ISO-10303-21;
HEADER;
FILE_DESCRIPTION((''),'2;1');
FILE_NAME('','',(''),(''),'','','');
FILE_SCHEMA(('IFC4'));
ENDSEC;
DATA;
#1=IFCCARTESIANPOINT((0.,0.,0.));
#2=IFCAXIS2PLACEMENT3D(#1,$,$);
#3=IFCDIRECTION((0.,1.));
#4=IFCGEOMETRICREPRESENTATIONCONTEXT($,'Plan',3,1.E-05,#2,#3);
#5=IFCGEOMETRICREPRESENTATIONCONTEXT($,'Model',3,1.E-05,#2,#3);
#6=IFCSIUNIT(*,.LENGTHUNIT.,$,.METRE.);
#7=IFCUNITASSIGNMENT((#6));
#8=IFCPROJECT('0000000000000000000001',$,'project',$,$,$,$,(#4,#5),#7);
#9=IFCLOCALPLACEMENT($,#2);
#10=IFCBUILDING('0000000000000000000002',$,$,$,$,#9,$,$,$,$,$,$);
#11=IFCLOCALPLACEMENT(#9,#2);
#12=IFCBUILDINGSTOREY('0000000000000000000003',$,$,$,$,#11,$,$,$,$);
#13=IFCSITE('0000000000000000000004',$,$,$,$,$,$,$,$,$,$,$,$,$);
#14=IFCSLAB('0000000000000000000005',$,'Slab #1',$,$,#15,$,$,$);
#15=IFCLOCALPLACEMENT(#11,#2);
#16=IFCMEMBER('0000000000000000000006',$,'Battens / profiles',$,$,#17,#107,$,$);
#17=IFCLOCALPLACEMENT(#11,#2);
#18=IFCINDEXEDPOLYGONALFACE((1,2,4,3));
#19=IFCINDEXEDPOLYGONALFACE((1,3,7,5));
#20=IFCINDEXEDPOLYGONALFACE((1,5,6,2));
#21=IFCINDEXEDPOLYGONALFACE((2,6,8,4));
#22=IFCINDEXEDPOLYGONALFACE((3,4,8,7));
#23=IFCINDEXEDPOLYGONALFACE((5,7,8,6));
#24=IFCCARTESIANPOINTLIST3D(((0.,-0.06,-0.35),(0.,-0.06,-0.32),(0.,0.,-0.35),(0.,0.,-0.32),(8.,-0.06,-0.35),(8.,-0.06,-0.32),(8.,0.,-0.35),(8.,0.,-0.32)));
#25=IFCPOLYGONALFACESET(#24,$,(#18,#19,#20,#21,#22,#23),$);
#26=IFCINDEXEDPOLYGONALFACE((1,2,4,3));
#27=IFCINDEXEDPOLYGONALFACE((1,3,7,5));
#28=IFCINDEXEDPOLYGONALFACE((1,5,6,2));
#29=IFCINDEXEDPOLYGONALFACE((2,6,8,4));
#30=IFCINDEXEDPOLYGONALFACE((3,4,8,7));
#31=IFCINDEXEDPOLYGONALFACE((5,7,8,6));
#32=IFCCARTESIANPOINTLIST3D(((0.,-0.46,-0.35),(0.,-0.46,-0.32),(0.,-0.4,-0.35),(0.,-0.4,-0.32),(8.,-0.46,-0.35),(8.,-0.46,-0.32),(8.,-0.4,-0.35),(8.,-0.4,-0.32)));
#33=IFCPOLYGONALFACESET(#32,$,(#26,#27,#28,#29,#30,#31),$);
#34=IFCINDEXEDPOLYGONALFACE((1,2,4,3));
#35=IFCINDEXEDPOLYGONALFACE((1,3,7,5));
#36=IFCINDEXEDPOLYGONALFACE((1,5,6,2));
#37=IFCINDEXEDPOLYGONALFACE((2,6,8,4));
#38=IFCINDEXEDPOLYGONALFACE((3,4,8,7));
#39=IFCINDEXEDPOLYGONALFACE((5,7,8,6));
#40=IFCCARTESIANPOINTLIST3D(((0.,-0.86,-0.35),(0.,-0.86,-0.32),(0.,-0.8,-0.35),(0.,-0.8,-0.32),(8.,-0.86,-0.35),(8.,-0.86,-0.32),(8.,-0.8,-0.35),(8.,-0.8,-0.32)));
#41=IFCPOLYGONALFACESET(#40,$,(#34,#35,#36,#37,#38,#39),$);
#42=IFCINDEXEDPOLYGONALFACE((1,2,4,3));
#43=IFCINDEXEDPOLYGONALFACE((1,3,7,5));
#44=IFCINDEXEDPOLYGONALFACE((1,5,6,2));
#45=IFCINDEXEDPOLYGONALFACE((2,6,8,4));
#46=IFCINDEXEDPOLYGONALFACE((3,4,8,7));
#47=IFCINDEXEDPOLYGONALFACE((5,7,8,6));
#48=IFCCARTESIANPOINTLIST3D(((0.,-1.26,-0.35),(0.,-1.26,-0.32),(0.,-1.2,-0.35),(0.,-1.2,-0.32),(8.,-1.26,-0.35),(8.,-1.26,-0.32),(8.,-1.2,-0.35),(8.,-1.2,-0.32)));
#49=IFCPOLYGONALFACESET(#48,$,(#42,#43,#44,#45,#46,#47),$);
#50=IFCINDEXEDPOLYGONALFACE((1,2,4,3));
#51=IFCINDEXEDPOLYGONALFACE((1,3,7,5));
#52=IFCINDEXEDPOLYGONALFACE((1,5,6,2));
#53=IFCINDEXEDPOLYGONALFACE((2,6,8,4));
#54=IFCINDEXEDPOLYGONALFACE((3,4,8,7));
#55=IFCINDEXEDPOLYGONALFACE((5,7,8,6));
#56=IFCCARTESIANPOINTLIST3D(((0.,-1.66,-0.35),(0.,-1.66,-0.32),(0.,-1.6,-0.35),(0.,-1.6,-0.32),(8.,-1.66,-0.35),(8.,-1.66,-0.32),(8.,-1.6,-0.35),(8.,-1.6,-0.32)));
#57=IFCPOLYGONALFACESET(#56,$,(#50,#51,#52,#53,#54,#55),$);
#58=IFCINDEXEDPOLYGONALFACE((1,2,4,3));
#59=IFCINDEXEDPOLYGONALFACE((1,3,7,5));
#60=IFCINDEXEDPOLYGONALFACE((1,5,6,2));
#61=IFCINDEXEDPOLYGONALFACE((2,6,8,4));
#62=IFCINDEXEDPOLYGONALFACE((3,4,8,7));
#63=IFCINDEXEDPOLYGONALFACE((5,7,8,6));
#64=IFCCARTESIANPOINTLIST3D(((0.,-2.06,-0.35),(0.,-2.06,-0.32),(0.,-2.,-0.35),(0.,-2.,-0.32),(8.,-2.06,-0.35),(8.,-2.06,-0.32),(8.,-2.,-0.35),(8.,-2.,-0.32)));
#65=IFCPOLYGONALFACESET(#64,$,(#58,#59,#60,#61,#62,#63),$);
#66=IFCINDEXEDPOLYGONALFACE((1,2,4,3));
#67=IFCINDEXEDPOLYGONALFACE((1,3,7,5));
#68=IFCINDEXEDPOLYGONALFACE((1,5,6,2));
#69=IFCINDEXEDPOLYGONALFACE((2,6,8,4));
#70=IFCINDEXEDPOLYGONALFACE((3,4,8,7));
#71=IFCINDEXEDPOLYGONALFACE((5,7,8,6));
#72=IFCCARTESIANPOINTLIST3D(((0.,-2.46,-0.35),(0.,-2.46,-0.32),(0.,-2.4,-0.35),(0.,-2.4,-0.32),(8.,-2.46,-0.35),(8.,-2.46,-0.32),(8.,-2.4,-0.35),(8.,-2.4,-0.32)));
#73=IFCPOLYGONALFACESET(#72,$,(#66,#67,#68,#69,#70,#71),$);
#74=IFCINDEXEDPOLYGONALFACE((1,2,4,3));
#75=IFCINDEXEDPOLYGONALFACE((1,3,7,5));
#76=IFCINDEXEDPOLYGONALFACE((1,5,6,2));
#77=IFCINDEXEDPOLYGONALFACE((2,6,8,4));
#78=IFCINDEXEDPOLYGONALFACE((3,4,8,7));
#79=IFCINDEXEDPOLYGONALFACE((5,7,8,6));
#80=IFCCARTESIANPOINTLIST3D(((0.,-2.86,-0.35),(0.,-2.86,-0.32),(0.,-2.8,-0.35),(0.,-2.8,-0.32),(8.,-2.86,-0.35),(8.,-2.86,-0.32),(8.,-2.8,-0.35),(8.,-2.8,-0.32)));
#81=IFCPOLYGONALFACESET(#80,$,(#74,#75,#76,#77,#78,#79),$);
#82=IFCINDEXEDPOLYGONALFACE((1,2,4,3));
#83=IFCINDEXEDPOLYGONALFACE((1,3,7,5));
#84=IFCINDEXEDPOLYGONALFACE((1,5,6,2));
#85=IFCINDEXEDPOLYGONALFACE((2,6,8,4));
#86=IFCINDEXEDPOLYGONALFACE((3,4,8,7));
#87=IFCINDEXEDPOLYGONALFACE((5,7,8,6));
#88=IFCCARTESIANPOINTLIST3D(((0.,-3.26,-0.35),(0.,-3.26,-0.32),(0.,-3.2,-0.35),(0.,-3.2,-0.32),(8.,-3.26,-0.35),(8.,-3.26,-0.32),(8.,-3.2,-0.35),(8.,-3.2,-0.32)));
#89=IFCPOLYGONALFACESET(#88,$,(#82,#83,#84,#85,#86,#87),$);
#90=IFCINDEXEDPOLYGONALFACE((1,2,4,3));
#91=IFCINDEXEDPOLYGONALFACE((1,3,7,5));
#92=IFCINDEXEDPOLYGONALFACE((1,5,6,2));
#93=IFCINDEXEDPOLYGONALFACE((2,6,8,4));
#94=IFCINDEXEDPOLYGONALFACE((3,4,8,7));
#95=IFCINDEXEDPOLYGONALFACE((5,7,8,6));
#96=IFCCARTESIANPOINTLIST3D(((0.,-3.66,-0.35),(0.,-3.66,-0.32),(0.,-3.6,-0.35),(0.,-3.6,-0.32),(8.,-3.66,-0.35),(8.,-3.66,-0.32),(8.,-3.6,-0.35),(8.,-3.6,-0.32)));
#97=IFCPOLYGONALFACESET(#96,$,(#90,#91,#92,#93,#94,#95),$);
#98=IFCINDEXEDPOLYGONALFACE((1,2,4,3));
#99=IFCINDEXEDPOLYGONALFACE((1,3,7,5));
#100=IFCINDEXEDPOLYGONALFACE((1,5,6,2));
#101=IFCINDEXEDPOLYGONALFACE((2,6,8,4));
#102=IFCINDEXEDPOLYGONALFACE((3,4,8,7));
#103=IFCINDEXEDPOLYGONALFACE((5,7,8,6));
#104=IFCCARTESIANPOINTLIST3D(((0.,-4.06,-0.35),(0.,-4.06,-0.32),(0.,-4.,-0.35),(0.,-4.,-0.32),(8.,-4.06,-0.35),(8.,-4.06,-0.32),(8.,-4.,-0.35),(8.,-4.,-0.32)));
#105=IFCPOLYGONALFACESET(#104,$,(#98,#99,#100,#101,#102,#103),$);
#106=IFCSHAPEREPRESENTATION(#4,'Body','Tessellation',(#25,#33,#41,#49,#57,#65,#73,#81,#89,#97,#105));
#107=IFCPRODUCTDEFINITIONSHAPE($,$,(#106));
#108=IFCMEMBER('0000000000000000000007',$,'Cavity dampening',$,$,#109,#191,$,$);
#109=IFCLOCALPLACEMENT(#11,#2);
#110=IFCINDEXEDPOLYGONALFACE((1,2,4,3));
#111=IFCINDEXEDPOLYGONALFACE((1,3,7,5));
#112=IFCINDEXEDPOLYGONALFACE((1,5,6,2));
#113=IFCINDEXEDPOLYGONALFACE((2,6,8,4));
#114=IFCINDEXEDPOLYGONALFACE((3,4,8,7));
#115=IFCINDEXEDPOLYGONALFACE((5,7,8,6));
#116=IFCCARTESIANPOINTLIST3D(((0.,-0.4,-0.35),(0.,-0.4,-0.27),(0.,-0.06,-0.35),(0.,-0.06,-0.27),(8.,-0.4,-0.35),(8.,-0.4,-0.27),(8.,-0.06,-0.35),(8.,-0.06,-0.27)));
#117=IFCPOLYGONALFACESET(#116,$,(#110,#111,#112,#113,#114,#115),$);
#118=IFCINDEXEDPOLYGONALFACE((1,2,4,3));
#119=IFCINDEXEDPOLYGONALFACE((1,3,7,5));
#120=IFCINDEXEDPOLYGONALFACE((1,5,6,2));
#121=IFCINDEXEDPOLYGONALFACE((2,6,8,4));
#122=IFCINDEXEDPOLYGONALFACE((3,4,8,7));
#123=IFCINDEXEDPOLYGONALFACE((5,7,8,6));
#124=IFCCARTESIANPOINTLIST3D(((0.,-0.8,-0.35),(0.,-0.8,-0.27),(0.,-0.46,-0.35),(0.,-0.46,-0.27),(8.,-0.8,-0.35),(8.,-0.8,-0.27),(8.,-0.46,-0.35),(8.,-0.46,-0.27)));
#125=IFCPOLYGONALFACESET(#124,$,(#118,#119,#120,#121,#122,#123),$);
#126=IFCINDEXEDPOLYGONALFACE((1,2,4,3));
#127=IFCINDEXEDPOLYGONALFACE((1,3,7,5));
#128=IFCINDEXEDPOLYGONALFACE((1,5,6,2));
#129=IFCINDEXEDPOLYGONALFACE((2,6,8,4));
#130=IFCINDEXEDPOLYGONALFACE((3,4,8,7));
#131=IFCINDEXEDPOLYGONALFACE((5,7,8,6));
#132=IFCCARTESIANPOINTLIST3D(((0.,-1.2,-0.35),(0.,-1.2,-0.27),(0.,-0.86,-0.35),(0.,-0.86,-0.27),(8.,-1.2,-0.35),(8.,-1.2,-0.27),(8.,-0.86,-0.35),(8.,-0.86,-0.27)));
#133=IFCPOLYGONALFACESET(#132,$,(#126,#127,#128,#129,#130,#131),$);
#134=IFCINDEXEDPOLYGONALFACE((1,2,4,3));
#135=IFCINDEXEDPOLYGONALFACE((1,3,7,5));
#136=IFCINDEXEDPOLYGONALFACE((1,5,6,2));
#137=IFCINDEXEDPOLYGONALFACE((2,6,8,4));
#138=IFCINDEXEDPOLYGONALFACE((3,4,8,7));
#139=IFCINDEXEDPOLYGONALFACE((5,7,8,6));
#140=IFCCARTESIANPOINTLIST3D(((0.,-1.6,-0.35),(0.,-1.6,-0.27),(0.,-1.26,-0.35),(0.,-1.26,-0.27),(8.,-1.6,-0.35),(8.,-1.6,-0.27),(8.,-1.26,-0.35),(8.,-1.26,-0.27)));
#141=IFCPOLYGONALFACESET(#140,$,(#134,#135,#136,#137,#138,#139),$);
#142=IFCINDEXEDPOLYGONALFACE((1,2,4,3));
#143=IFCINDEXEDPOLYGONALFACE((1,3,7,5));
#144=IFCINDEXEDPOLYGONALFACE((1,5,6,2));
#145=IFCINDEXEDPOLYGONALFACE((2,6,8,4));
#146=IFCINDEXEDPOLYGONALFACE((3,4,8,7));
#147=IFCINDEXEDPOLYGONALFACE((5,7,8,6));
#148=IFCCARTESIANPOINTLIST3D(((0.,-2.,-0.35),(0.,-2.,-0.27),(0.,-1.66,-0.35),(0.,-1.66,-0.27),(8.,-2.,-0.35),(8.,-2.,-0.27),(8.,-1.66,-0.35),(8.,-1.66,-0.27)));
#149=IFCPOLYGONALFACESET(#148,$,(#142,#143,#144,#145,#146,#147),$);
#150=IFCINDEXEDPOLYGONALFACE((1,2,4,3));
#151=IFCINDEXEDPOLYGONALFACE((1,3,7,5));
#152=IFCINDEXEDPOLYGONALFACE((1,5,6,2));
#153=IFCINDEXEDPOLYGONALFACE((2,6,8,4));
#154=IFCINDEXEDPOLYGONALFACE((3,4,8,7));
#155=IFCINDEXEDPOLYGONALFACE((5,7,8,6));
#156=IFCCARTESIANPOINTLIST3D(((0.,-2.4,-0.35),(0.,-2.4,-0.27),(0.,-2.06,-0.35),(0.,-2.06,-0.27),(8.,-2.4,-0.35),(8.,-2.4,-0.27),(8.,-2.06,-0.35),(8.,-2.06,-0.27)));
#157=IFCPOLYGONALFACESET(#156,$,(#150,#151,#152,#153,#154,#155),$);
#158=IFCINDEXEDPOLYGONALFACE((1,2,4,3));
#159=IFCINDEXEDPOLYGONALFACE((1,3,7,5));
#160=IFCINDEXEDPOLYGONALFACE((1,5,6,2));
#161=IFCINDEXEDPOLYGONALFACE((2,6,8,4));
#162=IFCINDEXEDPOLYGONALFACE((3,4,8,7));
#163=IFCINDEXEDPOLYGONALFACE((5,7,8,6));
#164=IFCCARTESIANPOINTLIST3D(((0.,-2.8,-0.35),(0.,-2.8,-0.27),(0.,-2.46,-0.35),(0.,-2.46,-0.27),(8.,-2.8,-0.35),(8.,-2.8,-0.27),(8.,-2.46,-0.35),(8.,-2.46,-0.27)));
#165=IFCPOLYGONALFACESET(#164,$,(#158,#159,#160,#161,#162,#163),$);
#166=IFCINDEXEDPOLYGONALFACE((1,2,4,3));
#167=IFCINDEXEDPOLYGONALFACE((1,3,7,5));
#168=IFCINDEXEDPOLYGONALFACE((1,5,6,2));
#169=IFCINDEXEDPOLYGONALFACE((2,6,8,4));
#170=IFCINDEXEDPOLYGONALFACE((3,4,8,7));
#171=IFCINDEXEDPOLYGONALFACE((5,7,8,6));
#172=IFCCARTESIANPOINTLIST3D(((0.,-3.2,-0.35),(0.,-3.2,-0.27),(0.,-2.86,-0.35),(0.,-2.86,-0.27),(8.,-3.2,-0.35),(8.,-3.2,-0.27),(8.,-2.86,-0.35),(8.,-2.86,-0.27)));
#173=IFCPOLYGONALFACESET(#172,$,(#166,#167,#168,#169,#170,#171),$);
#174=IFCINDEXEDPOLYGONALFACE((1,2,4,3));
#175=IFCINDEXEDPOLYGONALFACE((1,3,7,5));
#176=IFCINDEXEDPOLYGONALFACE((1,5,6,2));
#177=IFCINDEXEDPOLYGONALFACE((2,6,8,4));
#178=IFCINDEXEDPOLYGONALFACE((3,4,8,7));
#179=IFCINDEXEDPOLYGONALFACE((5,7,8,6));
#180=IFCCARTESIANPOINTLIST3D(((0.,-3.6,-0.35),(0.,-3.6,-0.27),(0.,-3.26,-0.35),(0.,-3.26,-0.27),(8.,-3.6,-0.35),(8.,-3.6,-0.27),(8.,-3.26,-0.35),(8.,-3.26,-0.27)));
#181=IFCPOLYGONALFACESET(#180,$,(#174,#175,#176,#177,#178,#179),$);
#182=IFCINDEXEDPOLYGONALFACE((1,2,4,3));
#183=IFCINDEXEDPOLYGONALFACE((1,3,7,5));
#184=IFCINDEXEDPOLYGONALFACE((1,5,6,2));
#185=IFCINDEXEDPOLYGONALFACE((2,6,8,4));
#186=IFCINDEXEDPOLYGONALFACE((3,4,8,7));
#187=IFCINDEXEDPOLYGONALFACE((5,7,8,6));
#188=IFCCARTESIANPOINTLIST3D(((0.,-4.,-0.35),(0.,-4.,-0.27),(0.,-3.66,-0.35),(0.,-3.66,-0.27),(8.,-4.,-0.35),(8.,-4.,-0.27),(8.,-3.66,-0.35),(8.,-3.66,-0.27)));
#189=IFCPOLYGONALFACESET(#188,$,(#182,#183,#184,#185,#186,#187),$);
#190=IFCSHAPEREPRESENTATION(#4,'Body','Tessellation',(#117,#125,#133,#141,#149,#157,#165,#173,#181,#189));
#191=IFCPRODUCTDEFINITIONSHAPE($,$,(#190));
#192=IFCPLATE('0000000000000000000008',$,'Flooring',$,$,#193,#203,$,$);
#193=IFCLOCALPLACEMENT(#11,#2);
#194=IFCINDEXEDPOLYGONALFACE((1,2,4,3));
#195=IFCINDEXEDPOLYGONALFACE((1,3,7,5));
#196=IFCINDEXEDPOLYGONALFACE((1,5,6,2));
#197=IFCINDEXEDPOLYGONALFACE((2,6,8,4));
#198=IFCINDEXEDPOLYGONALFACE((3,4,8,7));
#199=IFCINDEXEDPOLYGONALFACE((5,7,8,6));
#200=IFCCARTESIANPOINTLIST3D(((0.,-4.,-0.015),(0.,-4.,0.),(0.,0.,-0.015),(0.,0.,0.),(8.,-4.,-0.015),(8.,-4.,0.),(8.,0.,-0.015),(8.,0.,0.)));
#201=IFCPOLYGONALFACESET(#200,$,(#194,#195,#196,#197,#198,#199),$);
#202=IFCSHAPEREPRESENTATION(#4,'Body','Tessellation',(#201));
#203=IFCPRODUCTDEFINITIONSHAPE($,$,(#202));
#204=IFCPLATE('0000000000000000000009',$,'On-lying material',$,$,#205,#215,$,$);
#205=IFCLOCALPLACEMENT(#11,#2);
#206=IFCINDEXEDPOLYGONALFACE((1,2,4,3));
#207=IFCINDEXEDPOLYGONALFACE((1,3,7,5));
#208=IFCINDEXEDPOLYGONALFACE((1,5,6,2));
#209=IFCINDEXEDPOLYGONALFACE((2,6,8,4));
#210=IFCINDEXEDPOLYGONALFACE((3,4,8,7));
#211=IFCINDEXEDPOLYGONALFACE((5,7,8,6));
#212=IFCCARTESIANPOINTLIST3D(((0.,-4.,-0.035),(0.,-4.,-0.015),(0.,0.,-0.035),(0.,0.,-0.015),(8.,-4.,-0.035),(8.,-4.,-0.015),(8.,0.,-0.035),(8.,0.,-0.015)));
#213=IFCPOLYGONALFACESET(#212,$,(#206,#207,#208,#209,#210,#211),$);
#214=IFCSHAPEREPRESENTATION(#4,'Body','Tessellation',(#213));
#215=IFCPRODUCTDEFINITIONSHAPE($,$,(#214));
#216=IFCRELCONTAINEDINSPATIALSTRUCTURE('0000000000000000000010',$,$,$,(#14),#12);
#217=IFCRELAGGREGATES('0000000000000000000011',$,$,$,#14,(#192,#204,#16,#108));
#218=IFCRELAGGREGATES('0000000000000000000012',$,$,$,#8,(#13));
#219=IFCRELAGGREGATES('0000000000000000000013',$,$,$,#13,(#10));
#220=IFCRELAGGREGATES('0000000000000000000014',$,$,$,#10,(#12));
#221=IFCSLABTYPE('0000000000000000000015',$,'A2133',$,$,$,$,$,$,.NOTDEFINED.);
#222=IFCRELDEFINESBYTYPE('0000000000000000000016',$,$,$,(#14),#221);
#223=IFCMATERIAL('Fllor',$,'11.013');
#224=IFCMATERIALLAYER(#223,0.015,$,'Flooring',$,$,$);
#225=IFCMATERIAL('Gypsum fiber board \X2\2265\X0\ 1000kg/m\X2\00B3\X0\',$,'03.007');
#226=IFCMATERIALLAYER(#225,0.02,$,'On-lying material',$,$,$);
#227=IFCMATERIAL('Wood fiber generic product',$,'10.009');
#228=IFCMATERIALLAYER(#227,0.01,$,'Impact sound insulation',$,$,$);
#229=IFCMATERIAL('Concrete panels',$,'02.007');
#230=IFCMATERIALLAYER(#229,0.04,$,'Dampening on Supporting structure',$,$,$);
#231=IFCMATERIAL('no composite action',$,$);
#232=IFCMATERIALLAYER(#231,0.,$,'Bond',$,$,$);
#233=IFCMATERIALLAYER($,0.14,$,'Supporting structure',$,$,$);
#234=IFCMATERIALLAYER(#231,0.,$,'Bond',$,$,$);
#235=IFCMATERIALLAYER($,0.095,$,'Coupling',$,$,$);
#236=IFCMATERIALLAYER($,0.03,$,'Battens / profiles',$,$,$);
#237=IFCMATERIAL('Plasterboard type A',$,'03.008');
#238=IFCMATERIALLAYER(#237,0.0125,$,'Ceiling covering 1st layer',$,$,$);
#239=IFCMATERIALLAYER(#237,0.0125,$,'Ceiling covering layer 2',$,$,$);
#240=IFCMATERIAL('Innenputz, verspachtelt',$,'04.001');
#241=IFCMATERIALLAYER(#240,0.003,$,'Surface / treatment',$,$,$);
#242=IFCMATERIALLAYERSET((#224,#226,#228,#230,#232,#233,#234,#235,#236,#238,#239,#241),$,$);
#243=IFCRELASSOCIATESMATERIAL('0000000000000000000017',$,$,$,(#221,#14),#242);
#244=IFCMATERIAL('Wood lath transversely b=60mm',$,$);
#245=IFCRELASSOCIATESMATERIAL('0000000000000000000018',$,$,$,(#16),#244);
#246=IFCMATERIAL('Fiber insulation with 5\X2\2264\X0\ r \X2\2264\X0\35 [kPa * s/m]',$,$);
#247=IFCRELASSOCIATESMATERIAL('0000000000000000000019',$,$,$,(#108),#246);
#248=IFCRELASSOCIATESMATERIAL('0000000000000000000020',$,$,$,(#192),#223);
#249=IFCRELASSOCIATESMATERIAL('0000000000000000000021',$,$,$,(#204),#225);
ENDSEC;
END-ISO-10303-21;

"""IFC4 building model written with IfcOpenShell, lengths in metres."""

from ifc_helpers import new_model, si_unit, direction, frame, frame_2d, origin, origin_with_axes, place, context, project, spatial, rectangle, extrude, material, layer, layer_set, type_object, element, aggregate, save


model = new_model("IFC4")

# Units and contexts
plan_context = context("Plan", 3, precision=1e-05, world=origin(), true_north=direction((0.0, 1.0)))
model_context = context("Model", 3, precision=1e-05, world=origin(), true_north=direction((0.0, 1.0)))
ifc_project = project(units=[si_unit("LENGTHUNIT", "METRE")], contexts=[plan_context, model_context])

# Site, building, storey
site = spatial("IfcSite", under=ifc_project)
building_placement = place(None, origin())
building = spatial("IfcBuilding", under=site, at=building_placement)
storey_placement = place(building_placement, origin())
storey = spatial("IfcBuildingStorey", under=building, at=storey_placement)

# Slab, members, plates
ifc_material_1 = material(Name="Fllor", Category="11.013")
ifc_layer_1 = layer(ifc_material_1, 0.015, Name="Flooring")
ifc_material_2 = material(Name="Gypsum fiber board ≥ 1000kg/m³", Category="03.007")
ifc_layer_2 = layer(ifc_material_2, 0.02, Name="On-lying material")
ifc_material_3 = material(Name="Wood fiber generic product", Category="10.009")
ifc_layer_3 = layer(ifc_material_3, 0.01, Name="Impact sound insulation")
ifc_material_4 = material(Name="Concrete panels", Category="02.007")
ifc_layer_4 = layer(ifc_material_4, 0.04, Name="Dampening on Supporting structure")
ifc_material_5 = material(Name="no composite action")
ifc_layer_5 = layer(ifc_material_5, 0.0, Name="Bond")
ifc_layer_6 = layer(None, 0.14, Name="Supporting structure")
ifc_layer_7 = layer(ifc_material_5, 0.0, Name="Bond")
ifc_layer_8 = layer(None, 0.095, Name="Coupling")
ifc_layer_9 = layer(None, 0.03, Name="Battens / profiles")
ifc_material_6 = material(Name="Plasterboard type A", Category="03.008")
ifc_layer_10 = layer(ifc_material_6, 0.0125, Name="Ceiling covering 1st layer")
ifc_layer_11 = layer(ifc_material_6, 0.0125, Name="Ceiling covering layer 2")
ifc_material_7 = material(Name="Innenputz, verspachtelt", Category="04.001")
ifc_layer_12 = layer(ifc_material_7, 0.003, Name="Surface / treatment")
ifc_layer_set = layer_set([ifc_layer_1, ifc_layer_2, ifc_layer_3, ifc_layer_4, ifc_layer_5, ifc_layer_6, ifc_layer_7, ifc_layer_8, ifc_layer_9, ifc_layer_10, ifc_layer_11, ifc_layer_12])
slab_type = type_object("IfcSlabType", Name="A2133", PredefinedType="NOTDEFINED", material=ifc_layer_set)
slab_placement = place(None, frame((0.0, 0.0, 0.0), z_axis=(0.0, 0.0, -1.0), x_axis=(1.0, 0.0, 0.0)))
slab = element("IfcSlab", 1, at=slab_placement, inside=storey, type_object=slab_type, material=ifc_layer_set, Name="Slab #1")
ifc_material_8 = material(Name="Wood lath transversely b=60mm")
member_1_placement = place(slab_placement, origin())
member_1 = element("IfcMember", 2, at=member_1_placement, material=ifc_material_8, Name="Battens / profiles", context=plan_context, shape_type="SweptSolid", body=[
    extrude(rectangle(XDim=0.06, YDim=0.03, at=frame_2d((0.03, 0.015), x_axis=(1.0, 0.0))), frame((0.0, 0.0, 0.32), z_axis=(1.0, 0.0, 0.0), x_axis=(0.0, 1.0, 0.0)), (0.0, 0.0, 1.0), 8.0),
    extrude(rectangle(XDim=0.06, YDim=0.03, at=frame_2d((0.03, 0.015), x_axis=(1.0, 0.0))), frame((0.0, 0.4, 0.32), z_axis=(1.0, 0.0, 0.0), x_axis=(0.0, 1.0, 0.0)), (0.0, 0.0, 1.0), 8.0),
    extrude(rectangle(XDim=0.06, YDim=0.03, at=frame_2d((0.03, 0.015), x_axis=(1.0, 0.0))), frame((0.0, 0.8, 0.32), z_axis=(1.0, 0.0, 0.0), x_axis=(0.0, 1.0, 0.0)), (0.0, 0.0, 1.0), 8.0),
    extrude(rectangle(XDim=0.06, YDim=0.03, at=frame_2d((0.03, 0.015), x_axis=(1.0, 0.0))), frame((0.0, 1.2, 0.32), z_axis=(1.0, 0.0, 0.0), x_axis=(0.0, 1.0, 0.0)), (0.0, 0.0, 1.0), 8.0),
    extrude(rectangle(XDim=0.06, YDim=0.03, at=frame_2d((0.03, 0.015), x_axis=(1.0, 0.0))), frame((0.0, 1.6, 0.32), z_axis=(1.0, 0.0, 0.0), x_axis=(0.0, 1.0, 0.0)), (0.0, 0.0, 1.0), 8.0),
    extrude(rectangle(XDim=0.06, YDim=0.03, at=frame_2d((0.03, 0.015), x_axis=(1.0, 0.0))), frame((0.0, 2.0, 0.32), z_axis=(1.0, 0.0, 0.0), x_axis=(0.0, 1.0, 0.0)), (0.0, 0.0, 1.0), 8.0),
    extrude(rectangle(XDim=0.06, YDim=0.03, at=frame_2d((0.03, 0.015), x_axis=(1.0, 0.0))), frame((0.0, 2.4, 0.32), z_axis=(1.0, 0.0, 0.0), x_axis=(0.0, 1.0, 0.0)), (0.0, 0.0, 1.0), 8.0),
    extrude(rectangle(XDim=0.06, YDim=0.03, at=frame_2d((0.03, 0.015), x_axis=(1.0, 0.0))), frame((0.0, 2.8, 0.32), z_axis=(1.0, 0.0, 0.0), x_axis=(0.0, 1.0, 0.0)), (0.0, 0.0, 1.0), 8.0),
    extrude(rectangle(XDim=0.06, YDim=0.03, at=frame_2d((0.03, 0.015), x_axis=(1.0, 0.0))), frame((0.0, 3.2, 0.32), z_axis=(1.0, 0.0, 0.0), x_axis=(0.0, 1.0, 0.0)), (0.0, 0.0, 1.0), 8.0),
    extrude(rectangle(XDim=0.06, YDim=0.03, at=frame_2d((0.03, 0.015), x_axis=(1.0, 0.0))), frame((0.0, 3.6, 0.32), z_axis=(1.0, 0.0, 0.0), x_axis=(0.0, 1.0, 0.0)), (0.0, 0.0, 1.0), 8.0),
    extrude(rectangle(XDim=0.06, YDim=0.03, at=frame_2d((0.03, 0.015), x_axis=(1.0, 0.0))), frame((0.0, 4.0, 0.32), z_axis=(1.0, 0.0, 0.0), x_axis=(0.0, 1.0, 0.0)), (0.0, 0.0, 1.0), 8.0),
])
ifc_material_9 = material(Name="Fiber insulation with 5≤ r ≤35 [kPa * s/m]")
member_2_placement = place(slab_placement, origin())
member_2 = element("IfcMember", 3, at=member_2_placement, material=ifc_material_9, Name="Cavity dampening", context=plan_context, shape_type="SweptSolid", body=[
    extrude(rectangle(XDim=0.34, YDim=0.08, at=frame_2d((0.17, 0.04), x_axis=(1.0, 0.0))), frame((0.0, 0.06, 0.27), z_axis=(1.0, 0.0, 0.0), x_axis=(0.0, 1.0, 0.0)), (0.0, 0.0, 1.0), 8.0),
    extrude(rectangle(XDim=0.34, YDim=0.08, at=frame_2d((0.17, 0.04), x_axis=(1.0, 0.0))), frame((0.0, 0.46, 0.27), z_axis=(1.0, 0.0, 0.0), x_axis=(0.0, 1.0, 0.0)), (0.0, 0.0, 1.0), 8.0),
    extrude(rectangle(XDim=0.34, YDim=0.08, at=frame_2d((0.17, 0.04), x_axis=(1.0, 0.0))), frame((0.0, 0.86, 0.27), z_axis=(1.0, 0.0, 0.0), x_axis=(0.0, 1.0, 0.0)), (0.0, 0.0, 1.0), 8.0),
    extrude(rectangle(XDim=0.34, YDim=0.08, at=frame_2d((0.17, 0.04), x_axis=(1.0, 0.0))), frame((0.0, 1.26, 0.27), z_axis=(1.0, 0.0, 0.0), x_axis=(0.0, 1.0, 0.0)), (0.0, 0.0, 1.0), 8.0),
    extrude(rectangle(XDim=0.34, YDim=0.08, at=frame_2d((0.17, 0.04), x_axis=(1.0, 0.0))), frame((0.0, 1.66, 0.27), z_axis=(1.0, 0.0, 0.0), x_axis=(0.0, 1.0, 0.0)), (0.0, 0.0, 1.0), 8.0),
    extrude(rectangle(XDim=0.34, YDim=0.08, at=frame_2d((0.17, 0.04), x_axis=(1.0, 0.0))), frame((0.0, 2.06, 0.27), z_axis=(1.0, 0.0, 0.0), x_axis=(0.0, 1.0, 0.0)), (0.0, 0.0, 1.0), 8.0),
    extrude(rectangle(XDim=0.34, YDim=0.08, at=frame_2d((0.17, 0.04), x_axis=(1.0, 0.0))), frame((0.0, 2.46, 0.27), z_axis=(1.0, 0.0, 0.0), x_axis=(0.0, 1.0, 0.0)), (0.0, 0.0, 1.0), 8.0),
    extrude(rectangle(XDim=0.34, YDim=0.08, at=frame_2d((0.17, 0.04), x_axis=(1.0, 0.0))), frame((0.0, 2.86, 0.27), z_axis=(1.0, 0.0, 0.0), x_axis=(0.0, 1.0, 0.0)), (0.0, 0.0, 1.0), 8.0),
    extrude(rectangle(XDim=0.34, YDim=0.08, at=frame_2d((0.17, 0.04), x_axis=(1.0, 0.0))), frame((0.0, 3.26, 0.27), z_axis=(1.0, 0.0, 0.0), x_axis=(0.0, 1.0, 0.0)), (0.0, 0.0, 1.0), 8.0),
    extrude(rectangle(XDim=0.34, YDim=0.08, at=frame_2d((0.17, 0.04), x_axis=(1.0, 0.0))), frame((0.0, 3.66, 0.27), z_axis=(1.0, 0.0, 0.0), x_axis=(0.0, 1.0, 0.0)), (0.0, 0.0, 1.0), 8.0),
])
plate_1_placement = place(slab_placement, origin())
plate_1 = element("IfcPlate", 4, at=plate_1_placement, material=ifc_material_1, Name="Flooring", context=plan_context, shape_type="SweptSolid", body=[
    extrude(rectangle(XDim=8.0, YDim=4.0, at=frame_2d((4.0, 2.0), x_axis=(1.0, 0.0))), origin_with_axes(), (0.0, 0.0, 1.0), 0.015),
])
plate_2_placement = place(slab_placement, origin())
plate_2 = element("IfcPlate", 5, at=plate_2_placement, material=ifc_material_2, Name="On-lying material", context=plan_context, shape_type="SweptSolid", body=[
    extrude(rectangle(XDim=8.0, YDim=4.0, at=frame_2d((4.0, 2.0), x_axis=(1.0, 0.0))), frame((0.0, 0.0, 0.015), z_axis=(0.0, 0.0, 1.0), x_axis=(1.0, 0.0, 0.0)), (0.0, 0.0, 1.0), 0.02),
])
aggregate(slab, [plate_1, plate_2, member_1, member_2])

save(model, "model.ifc")
